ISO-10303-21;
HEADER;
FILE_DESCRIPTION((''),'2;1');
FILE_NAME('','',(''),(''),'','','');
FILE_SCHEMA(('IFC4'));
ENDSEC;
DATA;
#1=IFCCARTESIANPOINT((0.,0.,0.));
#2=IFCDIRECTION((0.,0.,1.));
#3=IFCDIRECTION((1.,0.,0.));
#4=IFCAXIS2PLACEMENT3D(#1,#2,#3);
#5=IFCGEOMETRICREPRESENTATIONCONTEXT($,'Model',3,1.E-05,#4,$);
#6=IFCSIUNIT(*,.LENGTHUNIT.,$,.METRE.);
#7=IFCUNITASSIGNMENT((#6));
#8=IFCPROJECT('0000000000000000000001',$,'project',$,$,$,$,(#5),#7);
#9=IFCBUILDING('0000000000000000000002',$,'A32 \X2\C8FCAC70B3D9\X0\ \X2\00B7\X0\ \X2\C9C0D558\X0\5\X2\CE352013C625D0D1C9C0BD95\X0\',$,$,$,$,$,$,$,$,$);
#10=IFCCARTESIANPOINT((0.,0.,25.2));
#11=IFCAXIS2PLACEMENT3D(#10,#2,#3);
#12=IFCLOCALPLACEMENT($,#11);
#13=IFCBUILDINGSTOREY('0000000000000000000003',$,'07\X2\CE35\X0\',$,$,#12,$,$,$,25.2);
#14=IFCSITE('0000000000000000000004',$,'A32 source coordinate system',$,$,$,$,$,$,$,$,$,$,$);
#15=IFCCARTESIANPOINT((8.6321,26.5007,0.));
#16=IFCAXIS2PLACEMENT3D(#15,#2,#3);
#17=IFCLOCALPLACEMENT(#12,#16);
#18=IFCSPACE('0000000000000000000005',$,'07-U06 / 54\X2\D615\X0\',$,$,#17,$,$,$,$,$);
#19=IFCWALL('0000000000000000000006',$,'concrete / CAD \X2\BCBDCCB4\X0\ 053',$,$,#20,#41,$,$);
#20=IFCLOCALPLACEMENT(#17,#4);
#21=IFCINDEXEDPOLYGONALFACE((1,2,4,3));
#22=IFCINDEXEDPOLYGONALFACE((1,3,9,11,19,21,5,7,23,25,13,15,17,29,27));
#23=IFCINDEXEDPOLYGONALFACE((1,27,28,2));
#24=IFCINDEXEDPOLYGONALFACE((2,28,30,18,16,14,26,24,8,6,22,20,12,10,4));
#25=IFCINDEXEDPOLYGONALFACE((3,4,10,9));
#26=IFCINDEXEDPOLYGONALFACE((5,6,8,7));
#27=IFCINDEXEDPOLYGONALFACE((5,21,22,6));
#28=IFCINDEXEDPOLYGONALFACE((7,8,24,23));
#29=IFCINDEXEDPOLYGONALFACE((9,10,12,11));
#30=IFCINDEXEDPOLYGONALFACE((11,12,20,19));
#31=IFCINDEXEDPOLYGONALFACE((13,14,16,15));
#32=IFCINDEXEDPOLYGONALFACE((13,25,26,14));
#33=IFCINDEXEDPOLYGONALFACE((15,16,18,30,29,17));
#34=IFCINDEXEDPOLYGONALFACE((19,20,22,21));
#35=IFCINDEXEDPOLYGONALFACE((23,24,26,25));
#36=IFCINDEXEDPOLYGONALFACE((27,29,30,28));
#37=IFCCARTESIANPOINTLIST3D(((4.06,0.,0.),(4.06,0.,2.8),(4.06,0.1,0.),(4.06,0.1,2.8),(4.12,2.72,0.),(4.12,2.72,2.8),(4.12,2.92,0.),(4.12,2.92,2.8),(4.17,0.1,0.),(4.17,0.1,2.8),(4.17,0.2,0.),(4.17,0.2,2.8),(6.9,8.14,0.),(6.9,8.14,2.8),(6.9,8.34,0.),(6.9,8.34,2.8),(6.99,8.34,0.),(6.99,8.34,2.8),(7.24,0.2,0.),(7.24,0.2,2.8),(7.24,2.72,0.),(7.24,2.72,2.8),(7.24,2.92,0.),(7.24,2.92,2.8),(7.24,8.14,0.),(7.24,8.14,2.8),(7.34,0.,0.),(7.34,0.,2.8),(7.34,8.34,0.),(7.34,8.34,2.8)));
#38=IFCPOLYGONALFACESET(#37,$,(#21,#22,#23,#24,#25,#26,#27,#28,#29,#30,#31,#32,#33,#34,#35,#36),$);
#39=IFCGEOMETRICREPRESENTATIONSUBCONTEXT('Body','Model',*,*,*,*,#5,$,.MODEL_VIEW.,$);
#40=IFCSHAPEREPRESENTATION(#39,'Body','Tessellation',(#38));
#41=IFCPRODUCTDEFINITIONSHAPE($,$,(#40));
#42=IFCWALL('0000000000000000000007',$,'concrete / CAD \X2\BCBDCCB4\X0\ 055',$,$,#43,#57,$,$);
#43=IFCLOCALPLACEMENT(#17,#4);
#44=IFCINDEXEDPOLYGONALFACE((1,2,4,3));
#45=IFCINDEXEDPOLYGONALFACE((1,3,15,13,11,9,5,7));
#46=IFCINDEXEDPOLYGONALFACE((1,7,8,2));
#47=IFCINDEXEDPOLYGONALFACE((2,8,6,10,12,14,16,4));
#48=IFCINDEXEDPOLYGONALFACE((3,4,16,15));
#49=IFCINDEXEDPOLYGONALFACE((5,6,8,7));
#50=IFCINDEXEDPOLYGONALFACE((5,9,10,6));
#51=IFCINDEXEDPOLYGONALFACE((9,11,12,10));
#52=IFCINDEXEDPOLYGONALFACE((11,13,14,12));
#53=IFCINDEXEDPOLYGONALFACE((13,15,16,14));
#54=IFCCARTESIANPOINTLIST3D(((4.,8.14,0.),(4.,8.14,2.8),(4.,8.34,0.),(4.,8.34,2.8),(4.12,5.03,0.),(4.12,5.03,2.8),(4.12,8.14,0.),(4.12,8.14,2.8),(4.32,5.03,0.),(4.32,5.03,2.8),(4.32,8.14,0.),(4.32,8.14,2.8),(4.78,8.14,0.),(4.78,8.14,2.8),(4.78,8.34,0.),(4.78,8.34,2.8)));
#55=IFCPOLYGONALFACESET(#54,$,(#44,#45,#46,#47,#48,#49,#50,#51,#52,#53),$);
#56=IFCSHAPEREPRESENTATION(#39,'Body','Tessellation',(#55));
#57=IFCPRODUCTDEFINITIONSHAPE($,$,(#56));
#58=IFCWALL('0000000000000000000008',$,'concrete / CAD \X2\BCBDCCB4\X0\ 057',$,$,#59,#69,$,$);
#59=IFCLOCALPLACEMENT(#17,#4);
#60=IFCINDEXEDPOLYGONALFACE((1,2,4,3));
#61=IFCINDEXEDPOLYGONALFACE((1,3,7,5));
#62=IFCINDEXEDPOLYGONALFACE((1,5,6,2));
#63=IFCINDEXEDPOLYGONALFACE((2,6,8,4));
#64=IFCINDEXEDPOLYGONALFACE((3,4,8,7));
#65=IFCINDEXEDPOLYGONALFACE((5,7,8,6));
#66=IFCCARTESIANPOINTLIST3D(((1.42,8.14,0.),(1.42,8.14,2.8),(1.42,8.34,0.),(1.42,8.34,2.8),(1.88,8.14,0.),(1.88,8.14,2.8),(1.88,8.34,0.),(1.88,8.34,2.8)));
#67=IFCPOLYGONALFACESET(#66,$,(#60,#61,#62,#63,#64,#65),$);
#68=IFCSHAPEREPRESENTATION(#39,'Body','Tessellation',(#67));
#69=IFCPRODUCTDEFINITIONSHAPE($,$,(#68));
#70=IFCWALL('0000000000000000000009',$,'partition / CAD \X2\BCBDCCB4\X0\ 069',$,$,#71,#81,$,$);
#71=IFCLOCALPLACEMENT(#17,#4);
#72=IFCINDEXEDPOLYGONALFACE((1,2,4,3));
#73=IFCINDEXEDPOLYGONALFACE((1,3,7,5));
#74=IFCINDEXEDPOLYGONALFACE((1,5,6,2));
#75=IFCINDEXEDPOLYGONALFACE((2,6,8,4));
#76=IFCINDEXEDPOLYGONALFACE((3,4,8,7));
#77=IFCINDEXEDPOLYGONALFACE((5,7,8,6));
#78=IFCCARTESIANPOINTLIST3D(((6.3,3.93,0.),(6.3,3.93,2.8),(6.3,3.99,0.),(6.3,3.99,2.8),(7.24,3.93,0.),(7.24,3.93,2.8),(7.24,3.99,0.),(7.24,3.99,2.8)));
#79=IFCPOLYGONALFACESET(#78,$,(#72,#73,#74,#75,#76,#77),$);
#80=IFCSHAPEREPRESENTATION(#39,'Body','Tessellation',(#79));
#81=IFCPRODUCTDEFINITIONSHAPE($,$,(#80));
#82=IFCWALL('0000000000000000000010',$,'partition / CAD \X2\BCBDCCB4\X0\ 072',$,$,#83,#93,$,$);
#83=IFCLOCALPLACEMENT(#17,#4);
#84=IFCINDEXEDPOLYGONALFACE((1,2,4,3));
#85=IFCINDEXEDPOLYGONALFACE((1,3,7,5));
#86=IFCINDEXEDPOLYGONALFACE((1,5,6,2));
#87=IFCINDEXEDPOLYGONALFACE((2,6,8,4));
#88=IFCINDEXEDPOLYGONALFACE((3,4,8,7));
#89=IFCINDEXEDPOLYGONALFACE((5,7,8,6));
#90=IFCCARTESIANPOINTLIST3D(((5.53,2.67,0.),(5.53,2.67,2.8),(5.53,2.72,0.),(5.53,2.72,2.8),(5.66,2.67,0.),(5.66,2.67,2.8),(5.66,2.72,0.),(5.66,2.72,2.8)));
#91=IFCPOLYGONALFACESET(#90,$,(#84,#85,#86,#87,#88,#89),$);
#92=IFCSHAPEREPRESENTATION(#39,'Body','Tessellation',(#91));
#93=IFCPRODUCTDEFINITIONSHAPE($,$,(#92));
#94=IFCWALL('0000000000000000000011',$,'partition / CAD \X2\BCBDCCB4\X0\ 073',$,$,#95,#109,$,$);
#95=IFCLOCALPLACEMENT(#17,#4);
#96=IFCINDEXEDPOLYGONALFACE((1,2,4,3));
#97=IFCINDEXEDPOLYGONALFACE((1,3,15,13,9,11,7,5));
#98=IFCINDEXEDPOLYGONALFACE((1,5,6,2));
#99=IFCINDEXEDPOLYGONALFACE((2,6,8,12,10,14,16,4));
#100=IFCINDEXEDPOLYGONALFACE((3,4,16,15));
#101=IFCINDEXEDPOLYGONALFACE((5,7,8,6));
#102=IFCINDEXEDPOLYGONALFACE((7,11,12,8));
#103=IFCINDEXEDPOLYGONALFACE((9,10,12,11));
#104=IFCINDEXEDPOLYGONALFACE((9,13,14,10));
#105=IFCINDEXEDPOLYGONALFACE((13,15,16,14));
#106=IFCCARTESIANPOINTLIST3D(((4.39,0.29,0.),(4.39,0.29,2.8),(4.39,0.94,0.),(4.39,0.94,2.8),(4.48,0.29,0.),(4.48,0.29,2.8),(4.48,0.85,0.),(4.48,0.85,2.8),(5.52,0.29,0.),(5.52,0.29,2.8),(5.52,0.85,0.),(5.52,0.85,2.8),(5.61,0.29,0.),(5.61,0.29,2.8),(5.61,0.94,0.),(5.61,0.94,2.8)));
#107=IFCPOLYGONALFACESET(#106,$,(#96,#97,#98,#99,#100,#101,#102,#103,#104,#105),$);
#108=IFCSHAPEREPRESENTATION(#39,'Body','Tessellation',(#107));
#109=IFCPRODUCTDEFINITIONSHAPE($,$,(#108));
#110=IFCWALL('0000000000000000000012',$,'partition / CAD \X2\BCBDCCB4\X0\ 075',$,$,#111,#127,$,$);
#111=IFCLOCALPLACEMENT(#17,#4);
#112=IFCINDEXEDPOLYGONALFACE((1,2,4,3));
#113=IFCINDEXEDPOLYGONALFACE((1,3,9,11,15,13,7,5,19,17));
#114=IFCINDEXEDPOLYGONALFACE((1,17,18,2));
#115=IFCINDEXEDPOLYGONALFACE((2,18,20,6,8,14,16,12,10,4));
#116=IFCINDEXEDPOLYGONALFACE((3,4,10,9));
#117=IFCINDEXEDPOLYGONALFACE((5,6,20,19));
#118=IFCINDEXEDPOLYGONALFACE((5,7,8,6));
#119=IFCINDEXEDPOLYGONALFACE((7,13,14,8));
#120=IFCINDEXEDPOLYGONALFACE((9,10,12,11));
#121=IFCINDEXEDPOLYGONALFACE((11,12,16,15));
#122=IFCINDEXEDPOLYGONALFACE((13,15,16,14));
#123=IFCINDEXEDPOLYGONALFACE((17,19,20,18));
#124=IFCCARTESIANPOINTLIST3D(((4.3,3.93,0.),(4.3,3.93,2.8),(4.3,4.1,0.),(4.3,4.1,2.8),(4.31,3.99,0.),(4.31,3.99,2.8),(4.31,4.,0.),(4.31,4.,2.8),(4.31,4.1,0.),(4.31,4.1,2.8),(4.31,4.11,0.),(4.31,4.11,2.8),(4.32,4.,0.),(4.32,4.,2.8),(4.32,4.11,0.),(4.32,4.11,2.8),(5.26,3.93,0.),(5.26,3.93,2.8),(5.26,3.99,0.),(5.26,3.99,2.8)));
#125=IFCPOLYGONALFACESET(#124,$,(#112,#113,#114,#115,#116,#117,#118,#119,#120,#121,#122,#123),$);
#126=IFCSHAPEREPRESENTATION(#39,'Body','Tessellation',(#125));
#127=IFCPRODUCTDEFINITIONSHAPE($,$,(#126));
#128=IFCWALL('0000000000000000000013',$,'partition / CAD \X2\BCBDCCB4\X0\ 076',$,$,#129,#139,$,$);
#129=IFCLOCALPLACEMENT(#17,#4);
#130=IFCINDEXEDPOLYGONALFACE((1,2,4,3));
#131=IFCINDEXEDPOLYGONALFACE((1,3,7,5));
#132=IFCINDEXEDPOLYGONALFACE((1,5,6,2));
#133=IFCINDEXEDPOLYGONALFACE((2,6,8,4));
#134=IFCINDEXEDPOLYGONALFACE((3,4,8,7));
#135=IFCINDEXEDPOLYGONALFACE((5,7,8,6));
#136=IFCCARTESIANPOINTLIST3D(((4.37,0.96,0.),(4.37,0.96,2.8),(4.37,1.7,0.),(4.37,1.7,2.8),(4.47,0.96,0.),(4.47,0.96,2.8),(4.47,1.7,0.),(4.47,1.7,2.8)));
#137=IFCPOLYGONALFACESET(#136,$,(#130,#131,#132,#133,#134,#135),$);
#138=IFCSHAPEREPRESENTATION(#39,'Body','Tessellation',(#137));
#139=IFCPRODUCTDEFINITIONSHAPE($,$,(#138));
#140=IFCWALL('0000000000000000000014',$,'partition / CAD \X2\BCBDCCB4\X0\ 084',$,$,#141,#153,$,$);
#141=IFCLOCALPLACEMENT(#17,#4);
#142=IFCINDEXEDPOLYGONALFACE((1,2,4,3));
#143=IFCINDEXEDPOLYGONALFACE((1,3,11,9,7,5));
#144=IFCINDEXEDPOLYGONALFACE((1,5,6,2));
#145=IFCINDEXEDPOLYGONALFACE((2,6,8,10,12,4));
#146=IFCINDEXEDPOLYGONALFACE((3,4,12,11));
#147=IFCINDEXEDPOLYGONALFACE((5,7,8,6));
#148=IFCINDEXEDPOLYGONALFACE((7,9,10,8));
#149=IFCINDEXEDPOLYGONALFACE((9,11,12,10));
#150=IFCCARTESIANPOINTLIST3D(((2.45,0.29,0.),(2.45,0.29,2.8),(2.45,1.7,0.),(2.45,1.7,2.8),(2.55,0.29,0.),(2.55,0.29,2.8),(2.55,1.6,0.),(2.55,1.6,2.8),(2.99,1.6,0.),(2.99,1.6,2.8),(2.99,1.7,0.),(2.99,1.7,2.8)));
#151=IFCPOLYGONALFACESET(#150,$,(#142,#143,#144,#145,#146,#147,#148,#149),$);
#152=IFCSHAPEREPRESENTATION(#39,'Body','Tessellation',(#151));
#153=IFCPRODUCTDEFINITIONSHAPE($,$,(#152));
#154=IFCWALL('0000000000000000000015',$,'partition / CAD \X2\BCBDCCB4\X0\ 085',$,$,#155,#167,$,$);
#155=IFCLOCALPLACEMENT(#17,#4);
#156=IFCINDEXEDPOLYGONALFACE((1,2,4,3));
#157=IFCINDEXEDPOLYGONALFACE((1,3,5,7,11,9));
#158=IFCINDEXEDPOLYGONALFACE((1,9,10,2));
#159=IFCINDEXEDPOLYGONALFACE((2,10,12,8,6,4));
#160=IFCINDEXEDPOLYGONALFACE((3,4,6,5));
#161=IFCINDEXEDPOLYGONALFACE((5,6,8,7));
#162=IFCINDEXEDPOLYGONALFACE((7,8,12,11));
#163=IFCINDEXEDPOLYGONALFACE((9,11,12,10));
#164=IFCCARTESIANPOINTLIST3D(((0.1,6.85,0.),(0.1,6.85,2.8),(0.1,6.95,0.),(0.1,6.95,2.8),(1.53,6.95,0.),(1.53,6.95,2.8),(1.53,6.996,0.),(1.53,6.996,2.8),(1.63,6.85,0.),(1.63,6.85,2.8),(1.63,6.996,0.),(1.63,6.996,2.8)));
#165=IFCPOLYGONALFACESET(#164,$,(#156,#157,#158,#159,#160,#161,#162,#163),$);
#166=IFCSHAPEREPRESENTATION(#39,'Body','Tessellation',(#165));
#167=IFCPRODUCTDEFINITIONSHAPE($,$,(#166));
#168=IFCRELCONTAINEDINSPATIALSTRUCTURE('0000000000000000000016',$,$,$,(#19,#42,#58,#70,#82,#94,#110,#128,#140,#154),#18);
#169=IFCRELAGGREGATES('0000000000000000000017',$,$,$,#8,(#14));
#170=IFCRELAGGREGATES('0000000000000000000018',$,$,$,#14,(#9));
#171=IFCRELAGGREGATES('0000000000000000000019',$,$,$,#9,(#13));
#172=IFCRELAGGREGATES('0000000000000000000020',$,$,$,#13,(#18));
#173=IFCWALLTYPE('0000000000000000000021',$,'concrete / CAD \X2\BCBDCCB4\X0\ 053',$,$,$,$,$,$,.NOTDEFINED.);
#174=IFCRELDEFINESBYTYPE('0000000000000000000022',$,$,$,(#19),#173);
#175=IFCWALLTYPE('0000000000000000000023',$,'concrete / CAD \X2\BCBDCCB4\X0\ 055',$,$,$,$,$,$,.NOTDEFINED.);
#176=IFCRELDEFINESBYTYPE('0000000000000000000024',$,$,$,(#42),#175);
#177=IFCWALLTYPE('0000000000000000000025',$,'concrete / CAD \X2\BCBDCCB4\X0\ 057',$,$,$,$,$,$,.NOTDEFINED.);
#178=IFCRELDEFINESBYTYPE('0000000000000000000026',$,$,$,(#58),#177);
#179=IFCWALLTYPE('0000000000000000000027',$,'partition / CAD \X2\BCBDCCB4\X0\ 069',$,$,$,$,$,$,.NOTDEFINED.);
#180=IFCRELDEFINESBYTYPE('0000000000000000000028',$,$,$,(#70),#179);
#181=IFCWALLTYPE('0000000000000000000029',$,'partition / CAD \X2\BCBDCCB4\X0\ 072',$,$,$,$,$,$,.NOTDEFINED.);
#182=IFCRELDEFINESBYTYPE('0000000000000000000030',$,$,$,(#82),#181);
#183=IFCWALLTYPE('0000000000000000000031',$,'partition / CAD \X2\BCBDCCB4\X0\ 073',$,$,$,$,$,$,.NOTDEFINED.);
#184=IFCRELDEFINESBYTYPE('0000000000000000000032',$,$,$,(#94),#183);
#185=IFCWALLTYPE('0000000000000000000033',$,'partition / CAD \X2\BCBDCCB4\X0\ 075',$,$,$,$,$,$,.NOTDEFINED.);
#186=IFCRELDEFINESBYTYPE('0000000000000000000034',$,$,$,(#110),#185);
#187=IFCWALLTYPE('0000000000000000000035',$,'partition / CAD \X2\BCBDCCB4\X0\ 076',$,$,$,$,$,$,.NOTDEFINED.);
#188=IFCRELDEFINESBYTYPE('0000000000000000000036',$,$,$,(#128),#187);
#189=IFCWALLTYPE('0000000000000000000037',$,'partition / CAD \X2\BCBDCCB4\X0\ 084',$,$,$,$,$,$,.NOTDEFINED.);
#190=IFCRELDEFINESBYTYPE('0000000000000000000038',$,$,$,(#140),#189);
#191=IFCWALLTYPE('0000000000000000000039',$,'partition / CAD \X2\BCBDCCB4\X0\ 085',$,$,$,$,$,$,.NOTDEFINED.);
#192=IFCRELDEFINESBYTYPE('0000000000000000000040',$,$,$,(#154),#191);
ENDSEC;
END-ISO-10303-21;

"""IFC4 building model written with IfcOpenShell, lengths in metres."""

from ifc_helpers import new_model, si_unit, frame, origin, origin_with_axes, place, context, subcontext, project, spatial, polyline, outline, extrude, source, transform, mapped, type_object, type_shapes, element, save


model = new_model("IFC4")

# Units and contexts
model_context = context("Model", 3, precision=1e-05, world=origin_with_axes())
body_context = subcontext(model_context, "Body", "Model", "MODEL_VIEW")
ifc_project = project(units=[si_unit("LENGTHUNIT", "METRE")], contexts=[model_context])

# Site, building, storey, space
site = spatial("IfcSite", under=ifc_project, Name="A32 source coordinate system")
building = spatial("IfcBuilding", under=site, Name="A32 주거동 · 지하5층–옥탑지붕")
storey_placement = place(None, frame((0.0, 0.0, 25.2), z_axis=(0.0, 0.0, 1.0), x_axis=(1.0, 0.0, 0.0)))
storey = spatial("IfcBuildingStorey", under=building, at=storey_placement, Name="07층", Elevation=25.2)
space_placement = place(storey_placement, frame((8.6321, 26.5007, 0.0), z_axis=(0.0, 0.0, 1.0), x_axis=(1.0, 0.0, 0.0)))
space = spatial("IfcSpace", under=storey, at=space_placement, Name="07-U06 / 54형")

# Walls
wall_type_1 = type_object("IfcWallType", Name="concrete / CAD 벽체 053", PredefinedType="NOTDEFINED")
shared_shape_1 = source(origin(), body_context, "Body", "SweptSolid", [
    extrude(outline(polyline([(7.24, 8.14), (6.9, 8.14), (6.9, 8.34), (6.99, 8.34), (6.99, 8.34), (7.34, 8.34), (7.34, 8.34), (7.34, 0.0), (4.06, 0.0), (4.06, 0.1), (4.17, 0.1), (4.17, 0.2), (7.24, 0.2), (7.24, 2.72), (4.12, 2.72), (4.12, 2.92), (7.24, 2.92), (7.24, 8.14)])), origin(), (0.0, 0.0, 1.0), 2.8),
])
type_shapes(wall_type_1, [shared_shape_1])
wall_1_placement = place(space_placement, origin_with_axes())
element("IfcWall", 1, at=wall_1_placement, inside=space, type_object=wall_type_1, Name="concrete / CAD 벽체 053", context=body_context, shape_type="MappedRepresentation", body=[
    mapped(shared_shape_1, transform((0.0, 0.0, 0.0), scale=1.0)),
])
wall_type_2 = type_object("IfcWallType", Name="concrete / CAD 벽체 055", PredefinedType="NOTDEFINED")
shared_shape_2 = source(origin(), body_context, "Body", "SweptSolid", [
    extrude(outline(polyline([(4.32, 5.03), (4.12, 5.03), (4.12, 8.14), (4.0, 8.14), (4.0, 8.34), (4.78, 8.34), (4.78, 8.14), (4.32, 8.14), (4.32, 5.03)])), origin(), (0.0, 0.0, 1.0), 2.8),
])
type_shapes(wall_type_2, [shared_shape_2])
wall_2_placement = place(space_placement, origin_with_axes())
element("IfcWall", 2, at=wall_2_placement, inside=space, type_object=wall_type_2, Name="concrete / CAD 벽체 055", context=body_context, shape_type="MappedRepresentation", body=[
    mapped(shared_shape_2, transform((0.0, 0.0, 0.0), scale=1.0)),
])
wall_type_3 = type_object("IfcWallType", Name="concrete / CAD 벽체 057", PredefinedType="NOTDEFINED")
shared_shape_3 = source(origin(), body_context, "Body", "SweptSolid", [
    extrude(outline(polyline([(1.42, 8.14), (1.42, 8.34), (1.88, 8.34), (1.88, 8.14), (1.42, 8.14)])), origin(), (0.0, 0.0, 1.0), 2.8),
])
type_shapes(wall_type_3, [shared_shape_3])
wall_3_placement = place(space_placement, origin_with_axes())
element("IfcWall", 3, at=wall_3_placement, inside=space, type_object=wall_type_3, Name="concrete / CAD 벽체 057", context=body_context, shape_type="MappedRepresentation", body=[
    mapped(shared_shape_3, transform((0.0, 0.0, 0.0), scale=1.0)),
])
wall_type_4 = type_object("IfcWallType", Name="partition / CAD 벽체 069", PredefinedType="NOTDEFINED")
shared_shape_4 = source(origin(), body_context, "Body", "SweptSolid", [
    extrude(outline(polyline([(7.24, 3.93), (6.3, 3.93), (6.3, 3.99), (7.24, 3.99), (7.24, 3.93)])), origin(), (0.0, 0.0, 1.0), 2.8),
])
type_shapes(wall_type_4, [shared_shape_4])
wall_4_placement = place(space_placement, origin_with_axes())
element("IfcWall", 4, at=wall_4_placement, inside=space, type_object=wall_type_4, Name="partition / CAD 벽체 069", context=body_context, shape_type="MappedRepresentation", body=[
    mapped(shared_shape_4, transform((0.0, 0.0, 0.0), scale=1.0)),
])
wall_type_5 = type_object("IfcWallType", Name="partition / CAD 벽체 072", PredefinedType="NOTDEFINED")
shared_shape_5 = source(origin(), body_context, "Body", "SweptSolid", [
    extrude(outline(polyline([(5.66, 2.67), (5.53, 2.67), (5.53, 2.72), (5.66, 2.72), (5.66, 2.67)])), origin(), (0.0, 0.0, 1.0), 2.8),
])
type_shapes(wall_type_5, [shared_shape_5])
wall_5_placement = place(space_placement, origin_with_axes())
element("IfcWall", 5, at=wall_5_placement, inside=space, type_object=wall_type_5, Name="partition / CAD 벽체 072", context=body_context, shape_type="MappedRepresentation", body=[
    mapped(shared_shape_5, transform((0.0, 0.0, 0.0), scale=1.0)),
])
wall_type_6 = type_object("IfcWallType", Name="partition / CAD 벽체 073", PredefinedType="NOTDEFINED")
shared_shape_6 = source(origin(), body_context, "Body", "SweptSolid", [
    extrude(outline(polyline([(4.48, 0.29), (4.39, 0.29), (4.39, 0.94), (5.61, 0.94), (5.61, 0.29), (5.52, 0.29), (5.52, 0.85), (4.48, 0.85), (4.48, 0.29)])), origin(), (0.0, 0.0, 1.0), 2.8),
])
type_shapes(wall_type_6, [shared_shape_6])
wall_6_placement = place(space_placement, origin_with_axes())
element("IfcWall", 6, at=wall_6_placement, inside=space, type_object=wall_type_6, Name="partition / CAD 벽체 073", context=body_context, shape_type="MappedRepresentation", body=[
    mapped(shared_shape_6, transform((0.0, 0.0, 0.0), scale=1.0)),
])
wall_type_7 = type_object("IfcWallType", Name="partition / CAD 벽체 075", PredefinedType="NOTDEFINED")
shared_shape_7 = source(origin(), body_context, "Body", "SweptSolid", [
    extrude(outline(polyline([(4.32, 4.0), (4.31, 4.0), (4.31, 3.99), (5.26, 3.99), (5.26, 3.93), (4.3, 3.93), (4.3, 4.1), (4.31, 4.1), (4.31, 4.11), (4.32, 4.11), (4.32, 4.0)])), origin(), (0.0, 0.0, 1.0), 2.8),
])
type_shapes(wall_type_7, [shared_shape_7])
wall_7_placement = place(space_placement, origin_with_axes())
element("IfcWall", 7, at=wall_7_placement, inside=space, type_object=wall_type_7, Name="partition / CAD 벽체 075", context=body_context, shape_type="MappedRepresentation", body=[
    mapped(shared_shape_7, transform((0.0, 0.0, 0.0), scale=1.0)),
])
wall_type_8 = type_object("IfcWallType", Name="partition / CAD 벽체 076", PredefinedType="NOTDEFINED")
shared_shape_8 = source(origin(), body_context, "Body", "SweptSolid", [
    extrude(outline(polyline([(4.37, 1.7), (4.47, 1.7), (4.47, 0.96), (4.37, 0.96), (4.37, 1.7)])), origin(), (0.0, 0.0, 1.0), 2.8),
])
type_shapes(wall_type_8, [shared_shape_8])
wall_8_placement = place(space_placement, origin_with_axes())
element("IfcWall", 8, at=wall_8_placement, inside=space, type_object=wall_type_8, Name="partition / CAD 벽체 076", context=body_context, shape_type="MappedRepresentation", body=[
    mapped(shared_shape_8, transform((0.0, 0.0, 0.0), scale=1.0)),
])
wall_type_9 = type_object("IfcWallType", Name="partition / CAD 벽체 084", PredefinedType="NOTDEFINED")
shared_shape_9 = source(origin(), body_context, "Body", "SweptSolid", [
    extrude(outline(polyline([(2.99, 1.6), (2.55, 1.6), (2.55, 0.29), (2.45, 0.29), (2.45, 1.7), (2.99, 1.7), (2.99, 1.6)])), origin(), (0.0, 0.0, 1.0), 2.8),
])
type_shapes(wall_type_9, [shared_shape_9])
wall_9_placement = place(space_placement, origin_with_axes())
element("IfcWall", 9, at=wall_9_placement, inside=space, type_object=wall_type_9, Name="partition / CAD 벽체 084", context=body_context, shape_type="MappedRepresentation", body=[
    mapped(shared_shape_9, transform((0.0, 0.0, 0.0), scale=1.0)),
])
wall_type_10 = type_object("IfcWallType", Name="partition / CAD 벽체 085", PredefinedType="NOTDEFINED")
shared_shape_10 = source(origin(), body_context, "Body", "SweptSolid", [
    extrude(outline(polyline([(1.63, 6.85), (0.1, 6.85), (0.1, 6.95), (1.53, 6.95), (1.53, 6.996), (1.63, 6.996), (1.63, 6.85)])), origin(), (0.0, 0.0, 1.0), 2.8),
])
type_shapes(wall_type_10, [shared_shape_10])
wall_10_placement = place(space_placement, origin_with_axes())
element("IfcWall", 10, at=wall_10_placement, inside=space, type_object=wall_type_10, Name="partition / CAD 벽체 085", context=body_context, shape_type="MappedRepresentation", body=[
    mapped(shared_shape_10, transform((0.0, 0.0, 0.0), scale=1.0)),
])

save(model, "model.ifc")
